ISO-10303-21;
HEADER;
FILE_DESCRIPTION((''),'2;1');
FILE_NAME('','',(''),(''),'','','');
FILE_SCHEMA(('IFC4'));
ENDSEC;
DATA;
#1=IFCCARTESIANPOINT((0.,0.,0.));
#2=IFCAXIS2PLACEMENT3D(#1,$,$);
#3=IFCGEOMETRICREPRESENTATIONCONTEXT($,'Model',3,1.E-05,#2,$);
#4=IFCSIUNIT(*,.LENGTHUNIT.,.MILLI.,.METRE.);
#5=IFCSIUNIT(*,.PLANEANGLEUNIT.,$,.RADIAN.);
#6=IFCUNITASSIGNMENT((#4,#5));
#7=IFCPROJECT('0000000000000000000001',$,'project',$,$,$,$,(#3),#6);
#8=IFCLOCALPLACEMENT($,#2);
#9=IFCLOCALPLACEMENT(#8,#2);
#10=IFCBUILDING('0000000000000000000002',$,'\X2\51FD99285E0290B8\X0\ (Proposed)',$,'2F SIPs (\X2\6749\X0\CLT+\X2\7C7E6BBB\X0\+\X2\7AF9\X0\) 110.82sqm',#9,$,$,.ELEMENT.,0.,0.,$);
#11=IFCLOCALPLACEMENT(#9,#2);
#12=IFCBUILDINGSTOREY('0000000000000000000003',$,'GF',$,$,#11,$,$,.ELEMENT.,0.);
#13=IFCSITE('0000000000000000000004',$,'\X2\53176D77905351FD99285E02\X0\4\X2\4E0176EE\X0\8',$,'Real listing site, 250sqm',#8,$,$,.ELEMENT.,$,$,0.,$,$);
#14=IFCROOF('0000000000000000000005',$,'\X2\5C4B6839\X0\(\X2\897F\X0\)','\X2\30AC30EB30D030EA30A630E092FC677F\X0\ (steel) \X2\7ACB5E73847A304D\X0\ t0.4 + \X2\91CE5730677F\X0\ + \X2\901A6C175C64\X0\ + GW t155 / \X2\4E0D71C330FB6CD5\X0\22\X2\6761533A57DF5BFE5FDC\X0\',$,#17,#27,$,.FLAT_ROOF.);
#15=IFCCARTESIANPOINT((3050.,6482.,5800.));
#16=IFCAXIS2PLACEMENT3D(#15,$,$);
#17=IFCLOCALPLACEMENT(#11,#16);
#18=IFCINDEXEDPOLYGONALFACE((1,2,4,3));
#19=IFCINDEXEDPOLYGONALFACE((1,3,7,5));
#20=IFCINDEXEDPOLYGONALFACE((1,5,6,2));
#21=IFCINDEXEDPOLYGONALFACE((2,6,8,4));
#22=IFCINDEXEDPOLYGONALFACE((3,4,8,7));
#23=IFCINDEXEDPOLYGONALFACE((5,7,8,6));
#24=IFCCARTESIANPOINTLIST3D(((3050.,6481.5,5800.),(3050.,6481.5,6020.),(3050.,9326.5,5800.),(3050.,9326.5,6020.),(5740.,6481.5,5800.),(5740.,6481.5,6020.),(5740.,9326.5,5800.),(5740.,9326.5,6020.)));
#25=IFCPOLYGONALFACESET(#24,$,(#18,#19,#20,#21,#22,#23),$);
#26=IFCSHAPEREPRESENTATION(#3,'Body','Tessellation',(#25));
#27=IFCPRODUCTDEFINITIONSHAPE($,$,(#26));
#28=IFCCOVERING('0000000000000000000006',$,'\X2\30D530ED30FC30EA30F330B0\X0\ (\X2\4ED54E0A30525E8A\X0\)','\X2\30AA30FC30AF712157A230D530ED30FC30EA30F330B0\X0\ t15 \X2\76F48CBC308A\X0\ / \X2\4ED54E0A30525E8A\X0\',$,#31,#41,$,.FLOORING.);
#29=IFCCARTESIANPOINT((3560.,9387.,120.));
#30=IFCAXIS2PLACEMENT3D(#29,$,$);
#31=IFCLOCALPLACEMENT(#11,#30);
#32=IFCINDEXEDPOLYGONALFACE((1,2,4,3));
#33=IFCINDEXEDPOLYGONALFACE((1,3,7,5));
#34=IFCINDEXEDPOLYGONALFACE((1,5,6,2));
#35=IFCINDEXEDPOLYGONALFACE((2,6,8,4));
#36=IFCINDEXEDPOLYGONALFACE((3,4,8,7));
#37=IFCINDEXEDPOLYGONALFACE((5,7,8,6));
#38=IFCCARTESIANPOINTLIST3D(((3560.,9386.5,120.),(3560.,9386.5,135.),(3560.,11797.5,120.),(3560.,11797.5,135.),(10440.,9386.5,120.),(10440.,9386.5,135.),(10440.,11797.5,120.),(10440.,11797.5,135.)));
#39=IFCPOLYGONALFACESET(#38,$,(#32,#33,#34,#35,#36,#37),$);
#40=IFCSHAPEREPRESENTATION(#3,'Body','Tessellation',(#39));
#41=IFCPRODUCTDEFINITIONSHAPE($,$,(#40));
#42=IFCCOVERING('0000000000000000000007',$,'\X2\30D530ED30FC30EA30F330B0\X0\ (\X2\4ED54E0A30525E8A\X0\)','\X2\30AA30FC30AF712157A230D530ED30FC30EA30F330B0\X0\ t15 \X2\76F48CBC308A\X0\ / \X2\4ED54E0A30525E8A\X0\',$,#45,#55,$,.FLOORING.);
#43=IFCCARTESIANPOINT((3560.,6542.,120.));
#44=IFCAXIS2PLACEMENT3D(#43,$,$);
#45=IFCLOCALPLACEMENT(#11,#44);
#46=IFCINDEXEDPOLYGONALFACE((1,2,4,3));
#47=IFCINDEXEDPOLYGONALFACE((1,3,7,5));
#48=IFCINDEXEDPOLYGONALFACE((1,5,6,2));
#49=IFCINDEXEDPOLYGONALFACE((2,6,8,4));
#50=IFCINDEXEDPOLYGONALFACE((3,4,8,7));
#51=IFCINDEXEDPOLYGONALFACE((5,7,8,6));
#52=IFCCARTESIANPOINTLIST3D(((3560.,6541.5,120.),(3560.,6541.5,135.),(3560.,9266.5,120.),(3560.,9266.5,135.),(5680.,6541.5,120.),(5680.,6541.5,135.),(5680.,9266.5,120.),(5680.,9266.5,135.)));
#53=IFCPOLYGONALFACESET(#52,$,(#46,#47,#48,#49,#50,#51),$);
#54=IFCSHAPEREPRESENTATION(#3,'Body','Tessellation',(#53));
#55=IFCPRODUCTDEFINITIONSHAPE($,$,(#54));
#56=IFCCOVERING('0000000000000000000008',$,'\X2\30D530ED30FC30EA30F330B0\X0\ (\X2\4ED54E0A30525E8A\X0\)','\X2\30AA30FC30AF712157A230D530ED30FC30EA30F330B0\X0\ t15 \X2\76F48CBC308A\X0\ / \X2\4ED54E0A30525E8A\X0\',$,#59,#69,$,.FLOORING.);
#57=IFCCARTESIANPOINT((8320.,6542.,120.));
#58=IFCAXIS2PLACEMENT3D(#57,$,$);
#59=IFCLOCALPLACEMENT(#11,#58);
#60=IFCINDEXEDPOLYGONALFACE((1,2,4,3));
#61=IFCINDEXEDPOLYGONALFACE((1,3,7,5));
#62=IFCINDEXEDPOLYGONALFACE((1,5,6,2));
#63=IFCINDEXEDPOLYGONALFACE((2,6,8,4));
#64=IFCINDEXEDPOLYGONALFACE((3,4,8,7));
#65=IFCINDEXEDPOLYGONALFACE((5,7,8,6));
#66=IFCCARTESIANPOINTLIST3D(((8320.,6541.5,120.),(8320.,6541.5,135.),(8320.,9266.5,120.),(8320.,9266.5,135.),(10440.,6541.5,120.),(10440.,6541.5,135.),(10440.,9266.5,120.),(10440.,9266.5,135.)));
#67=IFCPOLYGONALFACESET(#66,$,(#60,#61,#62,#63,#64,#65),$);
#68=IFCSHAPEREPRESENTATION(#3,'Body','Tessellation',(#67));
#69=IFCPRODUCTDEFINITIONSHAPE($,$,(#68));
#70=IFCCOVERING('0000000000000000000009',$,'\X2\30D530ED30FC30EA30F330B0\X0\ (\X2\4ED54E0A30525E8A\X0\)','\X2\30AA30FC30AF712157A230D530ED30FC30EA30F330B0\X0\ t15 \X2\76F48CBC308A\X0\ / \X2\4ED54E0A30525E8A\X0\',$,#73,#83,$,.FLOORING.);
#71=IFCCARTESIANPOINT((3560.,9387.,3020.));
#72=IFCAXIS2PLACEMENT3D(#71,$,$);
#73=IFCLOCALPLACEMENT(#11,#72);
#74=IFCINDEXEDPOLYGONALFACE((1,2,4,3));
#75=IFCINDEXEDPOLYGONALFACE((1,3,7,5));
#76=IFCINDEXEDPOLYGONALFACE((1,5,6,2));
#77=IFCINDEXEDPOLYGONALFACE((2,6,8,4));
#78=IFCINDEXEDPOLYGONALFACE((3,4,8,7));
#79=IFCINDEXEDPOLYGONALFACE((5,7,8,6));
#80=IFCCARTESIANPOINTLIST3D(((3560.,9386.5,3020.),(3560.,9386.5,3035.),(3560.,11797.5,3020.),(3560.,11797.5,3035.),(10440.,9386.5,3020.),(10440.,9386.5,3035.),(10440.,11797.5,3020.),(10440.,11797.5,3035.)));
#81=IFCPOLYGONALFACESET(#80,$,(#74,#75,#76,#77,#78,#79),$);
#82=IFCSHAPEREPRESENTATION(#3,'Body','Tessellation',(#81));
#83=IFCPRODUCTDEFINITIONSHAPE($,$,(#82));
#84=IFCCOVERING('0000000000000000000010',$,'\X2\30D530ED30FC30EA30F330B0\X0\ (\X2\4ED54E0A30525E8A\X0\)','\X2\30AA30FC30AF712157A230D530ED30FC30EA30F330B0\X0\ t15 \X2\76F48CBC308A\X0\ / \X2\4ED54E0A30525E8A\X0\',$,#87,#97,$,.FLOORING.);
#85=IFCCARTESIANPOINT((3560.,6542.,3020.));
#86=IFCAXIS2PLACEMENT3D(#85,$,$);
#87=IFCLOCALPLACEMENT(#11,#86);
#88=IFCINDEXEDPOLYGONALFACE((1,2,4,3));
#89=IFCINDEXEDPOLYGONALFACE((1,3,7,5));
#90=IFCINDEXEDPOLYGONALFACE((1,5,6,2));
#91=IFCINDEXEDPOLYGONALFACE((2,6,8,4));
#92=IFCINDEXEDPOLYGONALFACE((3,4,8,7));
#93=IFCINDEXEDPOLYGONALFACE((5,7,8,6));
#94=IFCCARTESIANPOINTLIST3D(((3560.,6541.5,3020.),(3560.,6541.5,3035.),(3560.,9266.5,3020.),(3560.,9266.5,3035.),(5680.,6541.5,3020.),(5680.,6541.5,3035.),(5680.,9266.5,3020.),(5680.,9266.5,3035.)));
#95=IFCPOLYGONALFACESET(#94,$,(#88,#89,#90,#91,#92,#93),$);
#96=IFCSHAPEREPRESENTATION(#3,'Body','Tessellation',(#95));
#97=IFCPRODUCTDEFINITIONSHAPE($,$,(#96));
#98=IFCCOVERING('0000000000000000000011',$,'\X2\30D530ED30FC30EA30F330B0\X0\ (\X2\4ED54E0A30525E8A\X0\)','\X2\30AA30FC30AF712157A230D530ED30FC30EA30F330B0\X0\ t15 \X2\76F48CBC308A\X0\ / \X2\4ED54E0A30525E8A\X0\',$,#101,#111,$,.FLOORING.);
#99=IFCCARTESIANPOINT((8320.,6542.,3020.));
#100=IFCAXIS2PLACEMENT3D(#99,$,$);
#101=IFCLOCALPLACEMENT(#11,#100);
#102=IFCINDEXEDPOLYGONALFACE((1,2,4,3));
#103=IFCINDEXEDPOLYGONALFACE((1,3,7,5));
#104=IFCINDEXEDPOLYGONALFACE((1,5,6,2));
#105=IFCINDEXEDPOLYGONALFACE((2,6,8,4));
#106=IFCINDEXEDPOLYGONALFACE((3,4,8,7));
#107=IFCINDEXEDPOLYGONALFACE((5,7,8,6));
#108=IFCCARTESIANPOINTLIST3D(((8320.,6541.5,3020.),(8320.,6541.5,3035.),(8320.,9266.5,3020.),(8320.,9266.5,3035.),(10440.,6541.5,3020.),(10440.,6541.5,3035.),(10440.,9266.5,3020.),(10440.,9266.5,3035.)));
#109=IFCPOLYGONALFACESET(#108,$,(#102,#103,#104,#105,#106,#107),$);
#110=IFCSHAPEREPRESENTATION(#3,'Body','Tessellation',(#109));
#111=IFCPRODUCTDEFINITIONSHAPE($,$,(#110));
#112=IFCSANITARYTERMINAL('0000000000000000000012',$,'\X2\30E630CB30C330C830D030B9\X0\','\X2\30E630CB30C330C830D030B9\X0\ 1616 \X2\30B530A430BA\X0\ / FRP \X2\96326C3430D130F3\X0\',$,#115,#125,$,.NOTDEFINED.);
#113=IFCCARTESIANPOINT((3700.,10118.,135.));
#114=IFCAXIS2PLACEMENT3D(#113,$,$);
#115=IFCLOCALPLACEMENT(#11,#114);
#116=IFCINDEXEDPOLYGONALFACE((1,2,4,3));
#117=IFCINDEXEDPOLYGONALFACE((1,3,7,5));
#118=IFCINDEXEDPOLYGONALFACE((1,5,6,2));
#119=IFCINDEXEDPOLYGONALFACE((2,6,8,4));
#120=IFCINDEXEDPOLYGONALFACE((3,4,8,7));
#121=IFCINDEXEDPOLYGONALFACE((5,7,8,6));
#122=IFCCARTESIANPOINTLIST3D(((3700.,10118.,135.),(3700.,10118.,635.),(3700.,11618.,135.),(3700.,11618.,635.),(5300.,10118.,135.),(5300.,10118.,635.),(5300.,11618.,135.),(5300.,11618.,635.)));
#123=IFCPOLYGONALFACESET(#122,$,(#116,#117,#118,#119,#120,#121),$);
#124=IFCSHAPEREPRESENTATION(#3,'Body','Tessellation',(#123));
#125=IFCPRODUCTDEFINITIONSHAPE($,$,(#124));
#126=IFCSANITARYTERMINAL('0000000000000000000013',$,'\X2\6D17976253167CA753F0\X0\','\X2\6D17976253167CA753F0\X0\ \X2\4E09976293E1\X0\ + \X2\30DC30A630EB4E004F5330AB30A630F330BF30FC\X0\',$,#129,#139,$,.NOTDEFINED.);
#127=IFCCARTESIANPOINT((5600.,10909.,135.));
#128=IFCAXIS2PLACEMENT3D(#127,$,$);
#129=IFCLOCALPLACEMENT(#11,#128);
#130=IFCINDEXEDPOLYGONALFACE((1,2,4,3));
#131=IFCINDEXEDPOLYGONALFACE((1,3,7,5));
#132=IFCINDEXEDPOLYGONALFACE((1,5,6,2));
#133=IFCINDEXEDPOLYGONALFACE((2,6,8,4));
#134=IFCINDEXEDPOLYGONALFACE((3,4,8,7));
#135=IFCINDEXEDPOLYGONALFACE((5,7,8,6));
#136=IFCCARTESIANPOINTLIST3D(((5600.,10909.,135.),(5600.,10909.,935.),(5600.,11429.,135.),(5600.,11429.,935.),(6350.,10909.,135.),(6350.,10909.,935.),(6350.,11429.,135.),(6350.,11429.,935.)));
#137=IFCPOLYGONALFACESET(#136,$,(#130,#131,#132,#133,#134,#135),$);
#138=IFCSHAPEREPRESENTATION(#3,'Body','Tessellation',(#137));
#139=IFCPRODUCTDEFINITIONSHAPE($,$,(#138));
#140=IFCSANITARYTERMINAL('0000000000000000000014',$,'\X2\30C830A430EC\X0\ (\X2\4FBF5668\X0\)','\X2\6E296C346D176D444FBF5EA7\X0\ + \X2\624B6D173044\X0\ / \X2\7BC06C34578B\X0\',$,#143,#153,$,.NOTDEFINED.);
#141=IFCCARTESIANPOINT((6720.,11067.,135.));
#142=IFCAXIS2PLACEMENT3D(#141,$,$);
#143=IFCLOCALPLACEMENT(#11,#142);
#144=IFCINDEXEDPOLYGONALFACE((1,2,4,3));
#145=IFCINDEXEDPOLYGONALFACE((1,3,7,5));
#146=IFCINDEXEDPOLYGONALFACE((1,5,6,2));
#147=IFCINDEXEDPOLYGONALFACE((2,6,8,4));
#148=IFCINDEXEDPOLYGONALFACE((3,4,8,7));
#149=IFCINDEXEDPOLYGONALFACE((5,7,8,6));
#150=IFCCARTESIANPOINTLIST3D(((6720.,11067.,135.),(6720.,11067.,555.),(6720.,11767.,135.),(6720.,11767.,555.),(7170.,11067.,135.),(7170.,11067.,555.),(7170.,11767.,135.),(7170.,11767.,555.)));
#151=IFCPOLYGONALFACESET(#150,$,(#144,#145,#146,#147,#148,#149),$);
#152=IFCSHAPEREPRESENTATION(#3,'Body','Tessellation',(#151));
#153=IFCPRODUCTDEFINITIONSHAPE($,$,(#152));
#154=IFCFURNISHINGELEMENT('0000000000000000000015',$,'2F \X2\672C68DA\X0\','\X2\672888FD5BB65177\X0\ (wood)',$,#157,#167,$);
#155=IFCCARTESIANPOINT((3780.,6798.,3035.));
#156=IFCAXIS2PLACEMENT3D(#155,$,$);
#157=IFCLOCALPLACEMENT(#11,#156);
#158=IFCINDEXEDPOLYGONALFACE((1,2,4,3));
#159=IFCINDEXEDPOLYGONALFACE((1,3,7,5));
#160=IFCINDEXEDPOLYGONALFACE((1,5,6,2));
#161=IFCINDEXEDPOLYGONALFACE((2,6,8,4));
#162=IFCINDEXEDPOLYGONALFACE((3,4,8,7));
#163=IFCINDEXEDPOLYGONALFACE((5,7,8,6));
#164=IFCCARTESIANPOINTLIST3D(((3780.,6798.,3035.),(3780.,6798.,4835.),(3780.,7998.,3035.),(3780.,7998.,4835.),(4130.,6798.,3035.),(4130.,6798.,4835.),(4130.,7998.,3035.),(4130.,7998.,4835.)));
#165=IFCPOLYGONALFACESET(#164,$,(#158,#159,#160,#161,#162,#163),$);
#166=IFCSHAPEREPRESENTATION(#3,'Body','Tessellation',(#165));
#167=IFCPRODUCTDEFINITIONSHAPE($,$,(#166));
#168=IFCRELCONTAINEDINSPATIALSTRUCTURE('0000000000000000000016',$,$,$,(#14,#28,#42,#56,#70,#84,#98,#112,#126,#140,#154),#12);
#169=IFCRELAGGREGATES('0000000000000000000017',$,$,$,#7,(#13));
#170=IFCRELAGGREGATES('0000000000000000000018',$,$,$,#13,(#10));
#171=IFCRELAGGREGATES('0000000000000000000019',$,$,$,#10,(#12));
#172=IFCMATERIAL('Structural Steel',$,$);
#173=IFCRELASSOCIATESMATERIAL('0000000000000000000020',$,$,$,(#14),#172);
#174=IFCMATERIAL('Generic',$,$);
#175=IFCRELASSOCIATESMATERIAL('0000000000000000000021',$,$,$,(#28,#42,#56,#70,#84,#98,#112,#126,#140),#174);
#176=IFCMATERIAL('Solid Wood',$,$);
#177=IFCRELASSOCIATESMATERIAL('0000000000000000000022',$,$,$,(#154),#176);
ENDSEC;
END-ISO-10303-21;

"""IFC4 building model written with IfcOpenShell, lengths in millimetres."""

from ifc_helpers import new_model, si_unit, frame, frame_2d, origin, place, context, project, spatial, rectangle, extrude, material, element, save


model = new_model("IFC4")

# Units and contexts
model_context = context("Model", 3, precision=1e-05, world=origin())
ifc_project = project(units=[si_unit("LENGTHUNIT", "METRE", prefix="MILLI"), si_unit("PLANEANGLEUNIT", "RADIAN")], contexts=[model_context])

# Site, building, storey
site_placement = place(None, origin())
site = spatial("IfcSite", under=ifc_project, at=site_placement, Name="北海道函館市4丁目8", ObjectType="Real listing site, 250sqm", CompositionType="ELEMENT", RefElevation=0.0)
building_placement = place(site_placement, origin())
building = spatial("IfcBuilding", under=site, at=building_placement, Name="函館市邸 (Proposed)", ObjectType="2F SIPs (杉CLT+籾殻+竹) 110.82sqm", CompositionType="ELEMENT", ElevationOfRefHeight=0.0, ElevationOfTerrain=0.0)
storey_placement = place(building_placement, origin())
storey = spatial("IfcBuildingStorey", under=building, at=storey_placement, Name="GF", CompositionType="ELEMENT", Elevation=0.0)

# Shared definitions
ifc_material_1 = material(Name="Solid Wood")

# Shared definitions
ifc_material_2 = material(Name="Generic")

# Roof
ifc_material_3 = material(Name="Structural Steel")
roof_1_placement = place(storey_placement, frame((3050.0, 6482.0, 5800.0)))
element("IfcRoof", 1, at=roof_1_placement, inside=storey, material=ifc_material_3, Name="屋根(西)", Description="ガルバリウム鋼板 (steel) 立平葺き t0.4 + 野地板 + 通気層 + GW t155 / 不燃・法22条区域対応", PredefinedType="FLAT_ROOF", context=model_context, shape_type="SweptSolid", body=[
    extrude(rectangle(XDim=2690.0, YDim=2845.0, at=frame_2d((1345.0, 1422.0))), frame((3050.0, 6482.0, 5800.0)), (0.0, 0.0, 1.0), 220.0),
])

# Coverings
covering_1_placement = place(storey_placement, frame((3560.0, 9387.0, 120.0)))
element("IfcCovering", 2, at=covering_1_placement, inside=storey, material=ifc_material_2, Name="フローリング (仕上げ床)", Description="オーク無垢フローリング t15 直貼り / 仕上げ床", PredefinedType="FLOORING", context=model_context, shape_type="SweptSolid", body=[
    extrude(rectangle(XDim=6880.0, YDim=2411.0, at=frame_2d((3440.0, 1205.0))), frame((3560.0, 9387.0, 120.0)), (0.0, 0.0, 1.0), 15.0),
])
covering_2_placement = place(storey_placement, frame((3560.0, 6542.0, 120.0)))
element("IfcCovering", 3, at=covering_2_placement, inside=storey, material=ifc_material_2, Name="フローリング (仕上げ床)", Description="オーク無垢フローリング t15 直貼り / 仕上げ床", PredefinedType="FLOORING", context=model_context, shape_type="SweptSolid", body=[
    extrude(rectangle(XDim=2120.0, YDim=2725.0, at=frame_2d((1060.0, 1362.0))), frame((3560.0, 6542.0, 120.0)), (0.0, 0.0, 1.0), 15.0),
])
covering_3_placement = place(storey_placement, frame((8320.0, 6542.0, 120.0)))
element("IfcCovering", 4, at=covering_3_placement, inside=storey, material=ifc_material_2, Name="フローリング (仕上げ床)", Description="オーク無垢フローリング t15 直貼り / 仕上げ床", PredefinedType="FLOORING", context=model_context, shape_type="SweptSolid", body=[
    extrude(rectangle(XDim=2120.0, YDim=2725.0, at=frame_2d((1060.0, 1362.0))), frame((8320.0, 6542.0, 120.0)), (0.0, 0.0, 1.0), 15.0),
])
covering_4_placement = place(storey_placement, frame((3560.0, 9387.0, 3020.0)))
element("IfcCovering", 5, at=covering_4_placement, inside=storey, material=ifc_material_2, Name="フローリング (仕上げ床)", Description="オーク無垢フローリング t15 直貼り / 仕上げ床", PredefinedType="FLOORING", context=model_context, shape_type="SweptSolid", body=[
    extrude(rectangle(XDim=6880.0, YDim=2411.0, at=frame_2d((3440.0, 1205.0))), frame((3560.0, 9387.0, 3020.0)), (0.0, 0.0, 1.0), 15.0),
])
covering_5_placement = place(storey_placement, frame((3560.0, 6542.0, 3020.0)))
element("IfcCovering", 6, at=covering_5_placement, inside=storey, material=ifc_material_2, Name="フローリング (仕上げ床)", Description="オーク無垢フローリング t15 直貼り / 仕上げ床", PredefinedType="FLOORING", context=model_context, shape_type="SweptSolid", body=[
    extrude(rectangle(XDim=2120.0, YDim=2725.0, at=frame_2d((1060.0, 1362.0))), frame((3560.0, 6542.0, 3020.0)), (0.0, 0.0, 1.0), 15.0),
])
covering_6_placement = place(storey_placement, frame((8320.0, 6542.0, 3020.0)))
element("IfcCovering", 7, at=covering_6_placement, inside=storey, material=ifc_material_2, Name="フローリング (仕上げ床)", Description="オーク無垢フローリング t15 直貼り / 仕上げ床", PredefinedType="FLOORING", context=model_context, shape_type="SweptSolid", body=[
    extrude(rectangle(XDim=2120.0, YDim=2725.0, at=frame_2d((1060.0, 1362.0))), frame((8320.0, 6542.0, 3020.0)), (0.0, 0.0, 1.0), 15.0),
])

# Sanitary terminals
sanitary_terminal_1_placement = place(storey_placement, frame((3700.0, 10118.0, 135.0)))
element("IfcSanitaryTerminal", 8, at=sanitary_terminal_1_placement, inside=storey, material=ifc_material_2, Name="ユニットバス", Description="ユニットバス 1616 サイズ / FRP 防水パン", PredefinedType="NOTDEFINED", context=model_context, shape_type="SweptSolid", body=[
    extrude(rectangle(XDim=1600.0, YDim=1500.0, at=frame_2d((800.0, 750.0))), frame((3700.0, 10118.0, 135.0)), (0.0, 0.0, 1.0), 500.0),
])
sanitary_terminal_2_placement = place(storey_placement, frame((5600.0, 10909.0, 135.0)))
element("IfcSanitaryTerminal", 9, at=sanitary_terminal_2_placement, inside=storey, material=ifc_material_2, Name="洗面化粧台", Description="洗面化粧台 三面鏡 + ボウル一体カウンター", PredefinedType="NOTDEFINED", context=model_context, shape_type="SweptSolid", body=[
    extrude(rectangle(XDim=750.0, YDim=520.0, at=frame_2d((375.0, 260.0))), frame((5600.0, 10909.0, 135.0)), (0.0, 0.0, 1.0), 800.0),
])
sanitary_terminal_3_placement = place(storey_placement, frame((6720.0, 11067.0, 135.0)))
element("IfcSanitaryTerminal", 10, at=sanitary_terminal_3_placement, inside=storey, material=ifc_material_2, Name="トイレ (便器)", Description="温水洗浄便座 + 手洗い / 節水型", PredefinedType="NOTDEFINED", context=model_context, shape_type="SweptSolid", body=[
    extrude(rectangle(XDim=450.0, YDim=700.0, at=frame_2d((225.0, 350.0))), frame((6720.0, 11067.0, 135.0)), (0.0, 0.0, 1.0), 420.0),
])

# Furnishing element
furnishing_placement = place(storey_placement, frame((3780.0, 6798.0, 3035.0)))
element("IfcFurnishingElement", 11, at=furnishing_placement, inside=storey, material=ifc_material_1, Name="2F 本棚", Description="木製家具 (wood)", context=model_context, shape_type="SweptSolid", body=[
    extrude(rectangle(XDim=350.0, YDim=1200.0, at=frame_2d((175.0, 600.0))), frame((3780.0, 6798.0, 3035.0)), (0.0, 0.0, 1.0), 1800.0),
])

save(model, "model.ifc")
